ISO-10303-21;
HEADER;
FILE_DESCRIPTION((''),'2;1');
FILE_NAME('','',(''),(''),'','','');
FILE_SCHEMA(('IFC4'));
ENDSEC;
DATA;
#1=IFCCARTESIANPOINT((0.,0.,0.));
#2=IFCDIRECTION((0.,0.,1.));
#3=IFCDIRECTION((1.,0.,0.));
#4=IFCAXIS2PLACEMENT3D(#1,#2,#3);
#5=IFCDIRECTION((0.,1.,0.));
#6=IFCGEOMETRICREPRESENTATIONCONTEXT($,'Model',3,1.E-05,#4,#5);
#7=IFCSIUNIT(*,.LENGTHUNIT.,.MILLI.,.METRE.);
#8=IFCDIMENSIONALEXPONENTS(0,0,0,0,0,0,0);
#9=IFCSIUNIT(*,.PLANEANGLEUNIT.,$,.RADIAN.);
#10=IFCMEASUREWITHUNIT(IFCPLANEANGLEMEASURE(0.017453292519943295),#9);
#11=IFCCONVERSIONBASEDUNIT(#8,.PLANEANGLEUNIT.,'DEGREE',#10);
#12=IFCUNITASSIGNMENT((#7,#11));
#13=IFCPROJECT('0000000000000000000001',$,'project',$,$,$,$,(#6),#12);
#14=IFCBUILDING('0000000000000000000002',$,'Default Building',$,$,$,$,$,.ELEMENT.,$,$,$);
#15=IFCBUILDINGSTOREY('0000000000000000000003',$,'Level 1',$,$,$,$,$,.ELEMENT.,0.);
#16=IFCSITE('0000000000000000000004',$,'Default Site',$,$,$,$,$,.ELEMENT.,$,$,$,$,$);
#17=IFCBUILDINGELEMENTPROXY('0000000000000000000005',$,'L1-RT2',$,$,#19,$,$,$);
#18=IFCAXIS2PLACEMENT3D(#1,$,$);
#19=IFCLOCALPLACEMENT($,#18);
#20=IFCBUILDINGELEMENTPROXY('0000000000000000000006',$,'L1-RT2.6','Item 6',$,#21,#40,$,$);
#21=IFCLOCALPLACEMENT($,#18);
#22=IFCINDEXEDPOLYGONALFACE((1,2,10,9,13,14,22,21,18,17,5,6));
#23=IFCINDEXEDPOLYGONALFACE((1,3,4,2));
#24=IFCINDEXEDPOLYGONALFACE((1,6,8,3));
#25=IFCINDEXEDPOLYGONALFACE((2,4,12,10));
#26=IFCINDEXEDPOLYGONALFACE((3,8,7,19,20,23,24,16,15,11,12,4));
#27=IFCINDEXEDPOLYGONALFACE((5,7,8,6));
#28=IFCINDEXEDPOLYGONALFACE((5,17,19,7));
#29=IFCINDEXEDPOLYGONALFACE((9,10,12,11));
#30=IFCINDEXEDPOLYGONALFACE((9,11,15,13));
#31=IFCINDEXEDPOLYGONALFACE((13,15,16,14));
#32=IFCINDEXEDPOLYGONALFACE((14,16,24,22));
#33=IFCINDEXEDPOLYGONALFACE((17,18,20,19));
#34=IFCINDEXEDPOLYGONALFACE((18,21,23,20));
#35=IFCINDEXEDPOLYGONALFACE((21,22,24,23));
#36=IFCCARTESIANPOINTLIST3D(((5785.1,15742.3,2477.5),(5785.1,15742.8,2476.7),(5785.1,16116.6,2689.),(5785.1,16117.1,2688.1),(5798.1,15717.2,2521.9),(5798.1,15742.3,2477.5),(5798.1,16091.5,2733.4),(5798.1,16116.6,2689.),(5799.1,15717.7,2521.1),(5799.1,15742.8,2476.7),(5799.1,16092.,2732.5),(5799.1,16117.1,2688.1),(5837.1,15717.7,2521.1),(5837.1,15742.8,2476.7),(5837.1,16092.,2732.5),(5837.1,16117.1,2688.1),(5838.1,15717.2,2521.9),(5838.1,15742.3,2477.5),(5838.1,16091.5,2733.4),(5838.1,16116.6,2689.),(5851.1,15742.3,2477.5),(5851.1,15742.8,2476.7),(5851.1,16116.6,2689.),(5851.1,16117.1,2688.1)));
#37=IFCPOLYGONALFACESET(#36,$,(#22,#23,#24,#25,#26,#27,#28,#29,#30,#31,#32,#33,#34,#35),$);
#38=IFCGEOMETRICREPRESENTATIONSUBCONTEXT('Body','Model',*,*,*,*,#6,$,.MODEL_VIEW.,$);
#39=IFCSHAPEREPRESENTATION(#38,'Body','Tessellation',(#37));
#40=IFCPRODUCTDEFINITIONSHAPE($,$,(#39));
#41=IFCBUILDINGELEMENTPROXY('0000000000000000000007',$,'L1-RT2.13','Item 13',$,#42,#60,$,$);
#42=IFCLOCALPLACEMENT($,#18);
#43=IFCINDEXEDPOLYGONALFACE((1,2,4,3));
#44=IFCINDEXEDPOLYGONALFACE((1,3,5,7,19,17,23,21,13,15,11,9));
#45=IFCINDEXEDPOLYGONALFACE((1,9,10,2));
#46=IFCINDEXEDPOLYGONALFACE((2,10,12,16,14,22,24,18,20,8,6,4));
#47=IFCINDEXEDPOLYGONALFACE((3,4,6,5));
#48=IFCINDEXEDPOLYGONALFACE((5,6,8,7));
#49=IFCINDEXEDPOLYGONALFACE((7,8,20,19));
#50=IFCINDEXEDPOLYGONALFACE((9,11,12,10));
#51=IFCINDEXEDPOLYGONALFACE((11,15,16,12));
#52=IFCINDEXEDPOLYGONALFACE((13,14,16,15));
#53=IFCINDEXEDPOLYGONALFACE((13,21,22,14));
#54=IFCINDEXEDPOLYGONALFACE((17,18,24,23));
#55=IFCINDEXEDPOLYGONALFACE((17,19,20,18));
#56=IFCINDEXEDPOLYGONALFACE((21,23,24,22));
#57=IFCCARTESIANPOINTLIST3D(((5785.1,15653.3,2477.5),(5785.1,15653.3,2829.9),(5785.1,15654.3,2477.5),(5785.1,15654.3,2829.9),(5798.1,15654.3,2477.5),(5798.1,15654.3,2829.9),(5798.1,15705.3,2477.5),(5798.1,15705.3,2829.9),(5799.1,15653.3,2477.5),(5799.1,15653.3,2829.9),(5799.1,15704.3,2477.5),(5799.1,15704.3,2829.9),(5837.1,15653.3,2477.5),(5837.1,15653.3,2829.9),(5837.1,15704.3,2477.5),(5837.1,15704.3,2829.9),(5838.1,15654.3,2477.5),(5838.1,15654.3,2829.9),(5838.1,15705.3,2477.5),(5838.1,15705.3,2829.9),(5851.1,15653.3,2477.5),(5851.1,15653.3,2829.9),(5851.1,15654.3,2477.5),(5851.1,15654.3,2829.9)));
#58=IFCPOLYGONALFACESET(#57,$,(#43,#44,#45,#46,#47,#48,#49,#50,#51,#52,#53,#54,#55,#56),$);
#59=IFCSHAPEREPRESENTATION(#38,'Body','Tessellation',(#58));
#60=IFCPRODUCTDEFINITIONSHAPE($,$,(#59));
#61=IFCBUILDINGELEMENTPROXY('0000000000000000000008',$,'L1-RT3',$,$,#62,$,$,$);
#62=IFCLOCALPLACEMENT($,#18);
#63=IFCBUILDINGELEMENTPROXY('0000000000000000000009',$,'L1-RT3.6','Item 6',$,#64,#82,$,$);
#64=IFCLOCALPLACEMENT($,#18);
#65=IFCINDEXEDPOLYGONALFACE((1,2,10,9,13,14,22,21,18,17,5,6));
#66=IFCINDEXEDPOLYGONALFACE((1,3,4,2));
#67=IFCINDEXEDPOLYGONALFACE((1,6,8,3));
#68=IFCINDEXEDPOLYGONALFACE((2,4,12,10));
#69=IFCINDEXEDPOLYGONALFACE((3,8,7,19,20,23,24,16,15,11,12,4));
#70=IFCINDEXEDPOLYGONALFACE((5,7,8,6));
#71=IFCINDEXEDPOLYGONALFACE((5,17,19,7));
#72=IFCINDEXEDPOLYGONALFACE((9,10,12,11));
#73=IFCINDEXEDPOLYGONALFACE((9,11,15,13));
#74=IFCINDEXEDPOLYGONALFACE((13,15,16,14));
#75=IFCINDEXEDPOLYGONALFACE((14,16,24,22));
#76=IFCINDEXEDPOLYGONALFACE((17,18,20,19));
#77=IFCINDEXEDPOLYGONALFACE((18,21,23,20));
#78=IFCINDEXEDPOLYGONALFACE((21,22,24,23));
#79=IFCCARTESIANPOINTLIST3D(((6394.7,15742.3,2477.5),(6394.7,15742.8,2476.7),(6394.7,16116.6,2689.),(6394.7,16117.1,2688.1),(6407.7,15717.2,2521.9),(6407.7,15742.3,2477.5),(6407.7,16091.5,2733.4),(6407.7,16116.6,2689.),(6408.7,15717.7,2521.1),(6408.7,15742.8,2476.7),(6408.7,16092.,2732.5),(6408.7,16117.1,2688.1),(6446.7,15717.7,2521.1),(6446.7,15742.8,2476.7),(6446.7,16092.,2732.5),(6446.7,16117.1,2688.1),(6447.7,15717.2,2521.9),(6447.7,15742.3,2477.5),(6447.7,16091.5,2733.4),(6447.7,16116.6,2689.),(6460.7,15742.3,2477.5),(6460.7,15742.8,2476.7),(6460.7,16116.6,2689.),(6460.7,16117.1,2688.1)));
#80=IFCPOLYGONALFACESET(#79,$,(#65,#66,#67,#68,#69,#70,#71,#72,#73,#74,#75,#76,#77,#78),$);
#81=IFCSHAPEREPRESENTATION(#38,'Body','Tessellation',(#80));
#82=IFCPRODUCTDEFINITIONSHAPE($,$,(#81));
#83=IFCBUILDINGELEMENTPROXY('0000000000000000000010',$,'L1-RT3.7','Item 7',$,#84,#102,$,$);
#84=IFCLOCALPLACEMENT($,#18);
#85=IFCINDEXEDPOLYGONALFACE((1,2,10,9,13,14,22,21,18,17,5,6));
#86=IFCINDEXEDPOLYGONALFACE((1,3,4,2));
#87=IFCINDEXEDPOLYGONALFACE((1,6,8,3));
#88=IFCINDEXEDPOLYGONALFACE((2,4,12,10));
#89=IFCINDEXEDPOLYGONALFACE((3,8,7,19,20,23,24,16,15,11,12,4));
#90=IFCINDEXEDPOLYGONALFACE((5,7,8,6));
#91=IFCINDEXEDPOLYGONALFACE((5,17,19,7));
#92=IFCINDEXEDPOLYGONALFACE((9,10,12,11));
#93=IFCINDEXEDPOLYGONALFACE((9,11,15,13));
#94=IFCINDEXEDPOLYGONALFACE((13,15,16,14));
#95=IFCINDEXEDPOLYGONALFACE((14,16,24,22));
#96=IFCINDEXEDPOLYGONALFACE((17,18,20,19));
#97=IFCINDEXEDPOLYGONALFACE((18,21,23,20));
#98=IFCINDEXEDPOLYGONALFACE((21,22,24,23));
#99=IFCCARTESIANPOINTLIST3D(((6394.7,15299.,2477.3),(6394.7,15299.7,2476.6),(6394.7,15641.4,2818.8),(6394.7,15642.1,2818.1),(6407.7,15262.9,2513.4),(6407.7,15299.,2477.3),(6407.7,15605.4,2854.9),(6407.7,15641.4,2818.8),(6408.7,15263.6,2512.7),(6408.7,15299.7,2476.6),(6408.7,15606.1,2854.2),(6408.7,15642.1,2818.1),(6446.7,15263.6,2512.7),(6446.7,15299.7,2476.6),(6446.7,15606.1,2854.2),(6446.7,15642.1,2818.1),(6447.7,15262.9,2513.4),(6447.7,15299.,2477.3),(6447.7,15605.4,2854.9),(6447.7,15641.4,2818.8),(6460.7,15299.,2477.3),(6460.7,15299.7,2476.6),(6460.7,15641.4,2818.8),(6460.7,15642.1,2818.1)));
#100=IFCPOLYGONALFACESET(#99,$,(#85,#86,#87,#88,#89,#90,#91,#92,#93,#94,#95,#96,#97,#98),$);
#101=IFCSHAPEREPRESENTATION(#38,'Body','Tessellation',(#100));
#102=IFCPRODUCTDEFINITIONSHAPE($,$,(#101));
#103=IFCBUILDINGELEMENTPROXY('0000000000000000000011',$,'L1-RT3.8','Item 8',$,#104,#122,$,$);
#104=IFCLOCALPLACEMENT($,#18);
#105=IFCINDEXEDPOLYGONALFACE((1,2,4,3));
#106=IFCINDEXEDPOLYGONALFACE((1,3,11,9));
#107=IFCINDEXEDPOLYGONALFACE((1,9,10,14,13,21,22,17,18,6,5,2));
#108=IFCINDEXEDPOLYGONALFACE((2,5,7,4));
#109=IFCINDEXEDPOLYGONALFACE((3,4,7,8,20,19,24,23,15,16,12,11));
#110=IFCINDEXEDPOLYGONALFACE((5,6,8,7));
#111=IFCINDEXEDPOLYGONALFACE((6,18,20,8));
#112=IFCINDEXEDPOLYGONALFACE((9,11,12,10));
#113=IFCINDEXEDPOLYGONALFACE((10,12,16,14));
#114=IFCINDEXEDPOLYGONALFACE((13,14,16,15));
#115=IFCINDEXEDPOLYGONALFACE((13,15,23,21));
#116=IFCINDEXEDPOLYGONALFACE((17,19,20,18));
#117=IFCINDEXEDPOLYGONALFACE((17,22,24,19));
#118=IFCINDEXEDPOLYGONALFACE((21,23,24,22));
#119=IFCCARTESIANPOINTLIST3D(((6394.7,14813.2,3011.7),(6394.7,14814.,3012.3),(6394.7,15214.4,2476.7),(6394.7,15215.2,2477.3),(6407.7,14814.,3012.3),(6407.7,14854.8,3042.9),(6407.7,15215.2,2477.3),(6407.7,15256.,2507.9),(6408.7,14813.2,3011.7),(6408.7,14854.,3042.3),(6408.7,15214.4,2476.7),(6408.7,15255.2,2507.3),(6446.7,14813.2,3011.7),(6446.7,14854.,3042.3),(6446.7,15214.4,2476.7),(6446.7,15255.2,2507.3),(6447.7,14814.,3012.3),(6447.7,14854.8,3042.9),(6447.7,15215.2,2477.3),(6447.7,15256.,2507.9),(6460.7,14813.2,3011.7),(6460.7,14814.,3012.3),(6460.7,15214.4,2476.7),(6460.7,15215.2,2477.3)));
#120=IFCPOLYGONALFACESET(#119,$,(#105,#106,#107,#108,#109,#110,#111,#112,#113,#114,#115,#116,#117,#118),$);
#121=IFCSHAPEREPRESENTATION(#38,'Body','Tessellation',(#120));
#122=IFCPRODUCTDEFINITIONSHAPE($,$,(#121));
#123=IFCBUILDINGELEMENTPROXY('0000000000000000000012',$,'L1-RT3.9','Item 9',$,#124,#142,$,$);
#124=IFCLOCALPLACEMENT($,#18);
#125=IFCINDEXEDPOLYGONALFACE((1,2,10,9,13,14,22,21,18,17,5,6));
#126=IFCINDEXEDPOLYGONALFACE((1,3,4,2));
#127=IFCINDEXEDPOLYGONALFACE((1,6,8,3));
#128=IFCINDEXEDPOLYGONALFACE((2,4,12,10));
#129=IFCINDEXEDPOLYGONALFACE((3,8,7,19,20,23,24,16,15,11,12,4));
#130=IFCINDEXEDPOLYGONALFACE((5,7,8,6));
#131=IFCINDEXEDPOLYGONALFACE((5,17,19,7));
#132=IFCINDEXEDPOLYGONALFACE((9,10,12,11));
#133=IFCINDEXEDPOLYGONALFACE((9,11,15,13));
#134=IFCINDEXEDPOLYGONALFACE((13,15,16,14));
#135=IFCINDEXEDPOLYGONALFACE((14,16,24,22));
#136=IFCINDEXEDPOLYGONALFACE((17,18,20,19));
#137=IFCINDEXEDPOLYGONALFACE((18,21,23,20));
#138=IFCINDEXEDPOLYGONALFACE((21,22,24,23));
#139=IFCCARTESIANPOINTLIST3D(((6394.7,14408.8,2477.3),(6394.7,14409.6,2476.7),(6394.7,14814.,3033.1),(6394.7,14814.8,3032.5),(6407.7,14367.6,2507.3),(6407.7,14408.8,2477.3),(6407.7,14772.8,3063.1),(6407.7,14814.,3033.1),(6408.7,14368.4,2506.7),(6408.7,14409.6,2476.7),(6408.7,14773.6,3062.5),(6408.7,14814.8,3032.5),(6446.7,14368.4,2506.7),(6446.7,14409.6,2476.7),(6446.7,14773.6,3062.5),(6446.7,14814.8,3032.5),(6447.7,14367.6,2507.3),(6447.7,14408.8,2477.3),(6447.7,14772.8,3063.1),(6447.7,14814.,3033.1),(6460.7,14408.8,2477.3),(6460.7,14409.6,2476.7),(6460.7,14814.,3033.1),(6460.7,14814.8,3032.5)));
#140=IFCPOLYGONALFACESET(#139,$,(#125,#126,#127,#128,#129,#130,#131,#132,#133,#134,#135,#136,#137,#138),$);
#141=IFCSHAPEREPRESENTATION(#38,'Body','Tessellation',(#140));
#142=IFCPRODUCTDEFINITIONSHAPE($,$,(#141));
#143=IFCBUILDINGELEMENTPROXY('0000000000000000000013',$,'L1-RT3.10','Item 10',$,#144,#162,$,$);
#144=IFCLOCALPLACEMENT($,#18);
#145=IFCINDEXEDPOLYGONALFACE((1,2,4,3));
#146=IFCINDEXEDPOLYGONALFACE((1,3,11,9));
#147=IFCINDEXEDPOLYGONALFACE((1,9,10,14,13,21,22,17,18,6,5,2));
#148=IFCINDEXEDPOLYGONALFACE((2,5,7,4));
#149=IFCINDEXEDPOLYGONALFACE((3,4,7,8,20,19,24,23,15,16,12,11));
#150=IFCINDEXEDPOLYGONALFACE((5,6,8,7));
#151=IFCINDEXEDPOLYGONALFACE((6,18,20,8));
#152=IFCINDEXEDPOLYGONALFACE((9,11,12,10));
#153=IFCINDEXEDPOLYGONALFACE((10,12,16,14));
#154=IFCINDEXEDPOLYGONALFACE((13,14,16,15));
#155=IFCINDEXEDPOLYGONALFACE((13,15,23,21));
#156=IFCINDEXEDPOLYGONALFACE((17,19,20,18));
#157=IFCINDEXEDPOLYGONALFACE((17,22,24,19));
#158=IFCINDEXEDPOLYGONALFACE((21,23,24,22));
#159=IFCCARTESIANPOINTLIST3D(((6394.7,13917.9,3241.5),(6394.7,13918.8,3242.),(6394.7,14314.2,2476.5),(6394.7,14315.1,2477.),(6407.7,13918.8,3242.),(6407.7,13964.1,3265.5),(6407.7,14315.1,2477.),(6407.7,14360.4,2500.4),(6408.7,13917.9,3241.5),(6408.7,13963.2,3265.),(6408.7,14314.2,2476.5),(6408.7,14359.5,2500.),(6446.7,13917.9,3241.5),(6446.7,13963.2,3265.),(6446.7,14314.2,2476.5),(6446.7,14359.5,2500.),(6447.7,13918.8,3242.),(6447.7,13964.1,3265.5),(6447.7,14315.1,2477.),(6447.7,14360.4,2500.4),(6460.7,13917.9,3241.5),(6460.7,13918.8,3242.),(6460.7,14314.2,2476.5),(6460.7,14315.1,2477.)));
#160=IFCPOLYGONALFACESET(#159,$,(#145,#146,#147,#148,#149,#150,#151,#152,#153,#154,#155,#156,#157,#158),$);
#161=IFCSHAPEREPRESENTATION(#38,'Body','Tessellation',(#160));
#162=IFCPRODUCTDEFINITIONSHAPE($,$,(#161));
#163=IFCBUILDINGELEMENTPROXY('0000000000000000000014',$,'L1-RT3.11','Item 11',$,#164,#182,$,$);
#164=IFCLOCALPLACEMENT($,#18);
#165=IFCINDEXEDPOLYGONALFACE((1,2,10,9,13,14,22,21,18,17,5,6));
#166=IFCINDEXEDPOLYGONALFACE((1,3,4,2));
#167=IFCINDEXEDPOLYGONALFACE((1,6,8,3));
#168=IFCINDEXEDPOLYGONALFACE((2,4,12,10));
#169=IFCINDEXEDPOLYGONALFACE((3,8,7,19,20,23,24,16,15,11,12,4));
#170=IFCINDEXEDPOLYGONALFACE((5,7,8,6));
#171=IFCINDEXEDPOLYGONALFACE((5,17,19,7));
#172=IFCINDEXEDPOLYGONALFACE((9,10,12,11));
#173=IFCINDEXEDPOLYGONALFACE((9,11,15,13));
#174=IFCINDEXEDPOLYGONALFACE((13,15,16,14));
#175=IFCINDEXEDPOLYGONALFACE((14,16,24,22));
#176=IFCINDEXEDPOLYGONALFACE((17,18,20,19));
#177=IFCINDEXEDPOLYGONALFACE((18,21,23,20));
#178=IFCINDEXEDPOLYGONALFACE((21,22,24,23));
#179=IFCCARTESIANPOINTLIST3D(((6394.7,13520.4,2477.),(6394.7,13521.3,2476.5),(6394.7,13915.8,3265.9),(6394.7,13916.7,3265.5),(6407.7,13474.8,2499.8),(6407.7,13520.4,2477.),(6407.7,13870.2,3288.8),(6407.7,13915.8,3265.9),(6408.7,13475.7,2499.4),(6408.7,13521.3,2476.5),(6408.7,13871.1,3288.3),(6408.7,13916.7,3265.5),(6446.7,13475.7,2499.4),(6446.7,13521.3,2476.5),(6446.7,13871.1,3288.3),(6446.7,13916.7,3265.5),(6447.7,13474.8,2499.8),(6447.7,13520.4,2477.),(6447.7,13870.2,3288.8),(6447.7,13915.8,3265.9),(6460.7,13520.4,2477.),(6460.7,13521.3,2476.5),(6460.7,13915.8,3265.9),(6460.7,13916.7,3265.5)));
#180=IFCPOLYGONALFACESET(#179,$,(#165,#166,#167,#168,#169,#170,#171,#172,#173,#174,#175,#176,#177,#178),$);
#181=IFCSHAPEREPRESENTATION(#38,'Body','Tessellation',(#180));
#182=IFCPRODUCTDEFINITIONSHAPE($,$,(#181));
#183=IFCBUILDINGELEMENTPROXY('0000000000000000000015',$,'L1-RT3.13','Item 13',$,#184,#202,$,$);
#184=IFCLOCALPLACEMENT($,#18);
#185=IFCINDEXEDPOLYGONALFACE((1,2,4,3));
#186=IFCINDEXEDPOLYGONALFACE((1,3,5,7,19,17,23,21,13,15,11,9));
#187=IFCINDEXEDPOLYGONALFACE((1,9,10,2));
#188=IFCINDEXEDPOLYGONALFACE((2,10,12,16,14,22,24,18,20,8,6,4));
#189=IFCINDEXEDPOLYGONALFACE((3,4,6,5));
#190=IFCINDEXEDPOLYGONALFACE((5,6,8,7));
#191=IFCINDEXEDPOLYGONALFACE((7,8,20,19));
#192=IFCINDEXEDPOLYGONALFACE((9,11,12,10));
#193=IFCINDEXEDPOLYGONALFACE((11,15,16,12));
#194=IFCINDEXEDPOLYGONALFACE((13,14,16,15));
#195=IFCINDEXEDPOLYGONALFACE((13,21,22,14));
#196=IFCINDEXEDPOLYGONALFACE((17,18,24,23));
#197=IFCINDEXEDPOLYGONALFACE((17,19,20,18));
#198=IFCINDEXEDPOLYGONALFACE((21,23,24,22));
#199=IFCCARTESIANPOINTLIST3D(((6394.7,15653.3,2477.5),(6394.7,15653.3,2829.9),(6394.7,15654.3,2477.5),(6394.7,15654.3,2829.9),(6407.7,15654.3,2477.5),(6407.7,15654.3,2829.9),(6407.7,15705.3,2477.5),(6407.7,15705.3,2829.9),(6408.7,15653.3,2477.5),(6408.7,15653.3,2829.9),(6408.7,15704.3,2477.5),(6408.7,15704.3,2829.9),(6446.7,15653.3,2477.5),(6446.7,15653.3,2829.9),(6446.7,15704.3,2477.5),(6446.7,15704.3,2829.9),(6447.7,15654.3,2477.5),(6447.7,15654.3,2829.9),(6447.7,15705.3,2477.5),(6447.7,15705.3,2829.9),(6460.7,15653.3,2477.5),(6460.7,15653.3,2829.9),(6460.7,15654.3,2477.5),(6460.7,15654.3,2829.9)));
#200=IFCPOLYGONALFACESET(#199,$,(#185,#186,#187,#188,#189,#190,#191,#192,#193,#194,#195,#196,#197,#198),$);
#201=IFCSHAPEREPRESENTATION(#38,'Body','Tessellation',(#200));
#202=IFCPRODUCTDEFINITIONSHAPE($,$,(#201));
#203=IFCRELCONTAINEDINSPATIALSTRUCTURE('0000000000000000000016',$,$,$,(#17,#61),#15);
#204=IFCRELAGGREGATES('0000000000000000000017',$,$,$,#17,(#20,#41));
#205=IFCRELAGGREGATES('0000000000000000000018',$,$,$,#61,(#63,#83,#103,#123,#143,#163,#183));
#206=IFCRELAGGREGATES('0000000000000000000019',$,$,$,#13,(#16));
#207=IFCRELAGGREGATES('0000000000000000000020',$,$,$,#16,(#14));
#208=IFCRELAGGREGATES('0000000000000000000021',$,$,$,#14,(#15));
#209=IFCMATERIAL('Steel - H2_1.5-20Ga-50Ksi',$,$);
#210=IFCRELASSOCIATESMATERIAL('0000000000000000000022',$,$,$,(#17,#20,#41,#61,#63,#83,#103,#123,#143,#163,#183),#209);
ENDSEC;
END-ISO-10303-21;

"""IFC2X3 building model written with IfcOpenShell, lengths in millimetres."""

from ifc_helpers import new_model, entity, si_unit, converted_unit, direction, frame, origin, origin_with_axes, place, context, subcontext, project, spatial, polyline, outline, extrude, material, element, aggregate, save


model = new_model("IFC2X3")

# Units and contexts
model_context = context("Model", 3, precision=1e-05, world=origin_with_axes(), true_north=direction((0.0, 1.0, 0.0)))
body_context = subcontext(model_context, "Body", "Model", "MODEL_VIEW")
ifc_project = project(units=[si_unit("LENGTHUNIT", "METRE", prefix="MILLI"), converted_unit("PLANEANGLEUNIT", "DEGREE", entity("IfcPlaneAngleMeasure", 0.017453292519943295), si_unit("PLANEANGLEUNIT", "RADIAN"), dimensions=[0, 0, 0, 0, 0, 0, 0])], contexts=[model_context])

# Site, building, storey
site = spatial("IfcSite", under=ifc_project, Name="Default Site", CompositionType="ELEMENT")
building = spatial("IfcBuilding", under=site, Name="Default Building", CompositionType="ELEMENT")
storey = spatial("IfcBuildingStorey", under=building, Name="Level 1", CompositionType="ELEMENT", Elevation=0.0)

# Building element proxies
ifc_material = material(Name="Steel - H2_1.5-20Ga-50Ksi")
proxy_1 = element("IfcBuildingElementProxy", 1, inside=storey, material=ifc_material, Name="L1-RT2")
proxy_2_placement = place(None, frame((5785.1, 16117.1, 2688.1), z_axis=(0.0, -0.871, -0.492), x_axis=(40.0, 0.0, 0.0)))
proxy_2 = element("IfcBuildingElementProxy", 2, at=proxy_2_placement, material=ifc_material, Name="L1-RT2.6", Description="Item 6", context=body_context, shape_type="SweptSolid", body=[
    extrude(outline(polyline([(0.0, 0.0), (14.0, 0.0), (14.0, 51.0), (52.0, 51.0), (52.0, 0.0), (66.0, 0.0), (66.0, 1.0), (53.0, 1.0), (53.0, 52.0), (13.0, 52.0), (13.0, 1.0), (0.0, 1.0), (0.0, 0.0)])), origin(), (0.0, 0.0, 1.0), 429.9),
])
proxy_3_placement = place(None, frame((5785.1, 15653.3, 2477.5), z_axis=(0.0, 0.0, 1.0), x_axis=(40.0, 0.0, 0.0)))
proxy_3 = element("IfcBuildingElementProxy", 3, at=proxy_3_placement, material=ifc_material, Name="L1-RT2.13", Description="Item 13", context=body_context, shape_type="SweptSolid", body=[
    extrude(outline(polyline([(0.0, 0.0), (14.0, 0.0), (14.0, 51.0), (52.0, 51.0), (52.0, 0.0), (66.0, 0.0), (66.0, 1.0), (53.0, 1.0), (53.0, 52.0), (13.0, 52.0), (13.0, 1.0), (0.0, 1.0), (0.0, 0.0)])), origin(), (0.0, 0.0, 1.0), 352.4),
])
aggregate(proxy_1, [proxy_2, proxy_3])
proxy_4 = element("IfcBuildingElementProxy", 4, inside=storey, material=ifc_material, Name="L1-RT3")
proxy_5_placement = place(None, frame((6394.7, 16117.1, 2688.1), z_axis=(0.0, -0.871, -0.492), x_axis=(40.0, 0.0, 0.0)))
proxy_5 = element("IfcBuildingElementProxy", 5, at=proxy_5_placement, material=ifc_material, Name="L1-RT3.6", Description="Item 6", context=body_context, shape_type="SweptSolid", body=[
    extrude(outline(polyline([(0.0, 0.0), (14.0, 0.0), (14.0, 51.0), (52.0, 51.0), (52.0, 0.0), (66.0, 0.0), (66.0, 1.0), (53.0, 1.0), (53.0, 52.0), (13.0, 52.0), (13.0, 1.0), (0.0, 1.0), (0.0, 0.0)])), origin(), (0.0, 0.0, 1.0), 429.9),
])
proxy_6_placement = place(None, frame((6394.7, 15642.1, 2818.1), z_axis=(0.0, -0.708, -0.706), x_axis=(40.0, 0.0, 0.0)))
proxy_6 = element("IfcBuildingElementProxy", 6, at=proxy_6_placement, material=ifc_material, Name="L1-RT3.7", Description="Item 7", context=body_context, shape_type="SweptSolid", body=[
    extrude(outline(polyline([(0.0, 0.0), (14.0, 0.0), (14.0, 51.0), (52.0, 51.0), (52.0, 0.0), (66.0, 0.0), (66.0, 1.0), (53.0, 1.0), (53.0, 52.0), (13.0, 52.0), (13.0, 1.0), (0.0, 1.0), (0.0, 0.0)])), origin(), (0.0, 0.0, 1.0), 483.6),
])
proxy_7_placement = place(None, frame((6394.7, 15214.4, 2476.7), z_axis=(0.0, -0.6, 0.8), x_axis=(40.0, 0.0, 0.0)))
proxy_7 = element("IfcBuildingElementProxy", 7, at=proxy_7_placement, material=ifc_material, Name="L1-RT3.8", Description="Item 8", context=body_context, shape_type="SweptSolid", body=[
    extrude(outline(polyline([(0.0, 0.0), (14.0, 0.0), (14.0, 51.0), (52.0, 51.0), (52.0, 0.0), (66.0, 0.0), (66.0, 1.0), (53.0, 1.0), (53.0, 52.0), (13.0, 52.0), (13.0, 1.0), (0.0, 1.0), (0.0, 0.0)])), origin(), (0.0, 0.0, 1.0), 668.7),
])
proxy_8_placement = place(None, frame((6394.7, 14814.8, 3032.5), z_axis=(0.0, -0.589, -0.808), x_axis=(40.0, 0.0, 0.0)))
proxy_8 = element("IfcBuildingElementProxy", 8, at=proxy_8_placement, material=ifc_material, Name="L1-RT3.9", Description="Item 9", context=body_context, shape_type="SweptSolid", body=[
    extrude(outline(polyline([(0.0, 0.0), (14.0, 0.0), (14.0, 51.0), (52.0, 51.0), (52.0, 0.0), (66.0, 0.0), (66.0, 1.0), (53.0, 1.0), (53.0, 52.0), (13.0, 52.0), (13.0, 1.0), (0.0, 1.0), (0.0, 0.0)])), origin(), (0.0, 0.0, 1.0), 687.8),
])
proxy_9_placement = place(None, frame((6394.7, 14314.2, 2476.5), z_axis=(0.0, -0.46, 0.888), x_axis=(40.0, 0.0, 0.0)))
proxy_9 = element("IfcBuildingElementProxy", 9, at=proxy_9_placement, material=ifc_material, Name="L1-RT3.10", Description="Item 10", context=body_context, shape_type="SweptSolid", body=[
    extrude(outline(polyline([(0.0, 0.0), (14.0, 0.0), (14.0, 51.0), (52.0, 51.0), (52.0, 0.0), (66.0, 0.0), (66.0, 1.0), (53.0, 1.0), (53.0, 52.0), (13.0, 52.0), (13.0, 1.0), (0.0, 1.0), (0.0, 0.0)])), origin(), (0.0, 0.0, 1.0), 861.6),
])
proxy_10_placement = place(None, frame((6394.7, 13916.7, 3265.5), z_axis=(0.0, -0.448, -0.894), x_axis=(40.0, 0.0, 0.0)))
proxy_10 = element("IfcBuildingElementProxy", 10, at=proxy_10_placement, material=ifc_material, Name="L1-RT3.11", Description="Item 11", context=body_context, shape_type="SweptSolid", body=[
    extrude(outline(polyline([(0.0, 0.0), (14.0, 0.0), (14.0, 51.0), (52.0, 51.0), (52.0, 0.0), (66.0, 0.0), (66.0, 1.0), (53.0, 1.0), (53.0, 52.0), (13.0, 52.0), (13.0, 1.0), (0.0, 1.0), (0.0, 0.0)])), origin(), (0.0, 0.0, 1.0), 882.5),
])
proxy_11_placement = place(None, frame((6394.7, 15653.3, 2477.5), z_axis=(0.0, 0.0, 1.0), x_axis=(40.0, 0.0, 0.0)))
proxy_11 = element("IfcBuildingElementProxy", 11, at=proxy_11_placement, material=ifc_material, Name="L1-RT3.13", Description="Item 13", context=body_context, shape_type="SweptSolid", body=[
    extrude(outline(polyline([(0.0, 0.0), (14.0, 0.0), (14.0, 51.0), (52.0, 51.0), (52.0, 0.0), (66.0, 0.0), (66.0, 1.0), (53.0, 1.0), (53.0, 52.0), (13.0, 52.0), (13.0, 1.0), (0.0, 1.0), (0.0, 0.0)])), origin(), (0.0, 0.0, 1.0), 352.4),
])
aggregate(proxy_4, [proxy_5, proxy_6, proxy_7, proxy_8, proxy_9, proxy_10, proxy_11])

save(model, "model.ifc")
